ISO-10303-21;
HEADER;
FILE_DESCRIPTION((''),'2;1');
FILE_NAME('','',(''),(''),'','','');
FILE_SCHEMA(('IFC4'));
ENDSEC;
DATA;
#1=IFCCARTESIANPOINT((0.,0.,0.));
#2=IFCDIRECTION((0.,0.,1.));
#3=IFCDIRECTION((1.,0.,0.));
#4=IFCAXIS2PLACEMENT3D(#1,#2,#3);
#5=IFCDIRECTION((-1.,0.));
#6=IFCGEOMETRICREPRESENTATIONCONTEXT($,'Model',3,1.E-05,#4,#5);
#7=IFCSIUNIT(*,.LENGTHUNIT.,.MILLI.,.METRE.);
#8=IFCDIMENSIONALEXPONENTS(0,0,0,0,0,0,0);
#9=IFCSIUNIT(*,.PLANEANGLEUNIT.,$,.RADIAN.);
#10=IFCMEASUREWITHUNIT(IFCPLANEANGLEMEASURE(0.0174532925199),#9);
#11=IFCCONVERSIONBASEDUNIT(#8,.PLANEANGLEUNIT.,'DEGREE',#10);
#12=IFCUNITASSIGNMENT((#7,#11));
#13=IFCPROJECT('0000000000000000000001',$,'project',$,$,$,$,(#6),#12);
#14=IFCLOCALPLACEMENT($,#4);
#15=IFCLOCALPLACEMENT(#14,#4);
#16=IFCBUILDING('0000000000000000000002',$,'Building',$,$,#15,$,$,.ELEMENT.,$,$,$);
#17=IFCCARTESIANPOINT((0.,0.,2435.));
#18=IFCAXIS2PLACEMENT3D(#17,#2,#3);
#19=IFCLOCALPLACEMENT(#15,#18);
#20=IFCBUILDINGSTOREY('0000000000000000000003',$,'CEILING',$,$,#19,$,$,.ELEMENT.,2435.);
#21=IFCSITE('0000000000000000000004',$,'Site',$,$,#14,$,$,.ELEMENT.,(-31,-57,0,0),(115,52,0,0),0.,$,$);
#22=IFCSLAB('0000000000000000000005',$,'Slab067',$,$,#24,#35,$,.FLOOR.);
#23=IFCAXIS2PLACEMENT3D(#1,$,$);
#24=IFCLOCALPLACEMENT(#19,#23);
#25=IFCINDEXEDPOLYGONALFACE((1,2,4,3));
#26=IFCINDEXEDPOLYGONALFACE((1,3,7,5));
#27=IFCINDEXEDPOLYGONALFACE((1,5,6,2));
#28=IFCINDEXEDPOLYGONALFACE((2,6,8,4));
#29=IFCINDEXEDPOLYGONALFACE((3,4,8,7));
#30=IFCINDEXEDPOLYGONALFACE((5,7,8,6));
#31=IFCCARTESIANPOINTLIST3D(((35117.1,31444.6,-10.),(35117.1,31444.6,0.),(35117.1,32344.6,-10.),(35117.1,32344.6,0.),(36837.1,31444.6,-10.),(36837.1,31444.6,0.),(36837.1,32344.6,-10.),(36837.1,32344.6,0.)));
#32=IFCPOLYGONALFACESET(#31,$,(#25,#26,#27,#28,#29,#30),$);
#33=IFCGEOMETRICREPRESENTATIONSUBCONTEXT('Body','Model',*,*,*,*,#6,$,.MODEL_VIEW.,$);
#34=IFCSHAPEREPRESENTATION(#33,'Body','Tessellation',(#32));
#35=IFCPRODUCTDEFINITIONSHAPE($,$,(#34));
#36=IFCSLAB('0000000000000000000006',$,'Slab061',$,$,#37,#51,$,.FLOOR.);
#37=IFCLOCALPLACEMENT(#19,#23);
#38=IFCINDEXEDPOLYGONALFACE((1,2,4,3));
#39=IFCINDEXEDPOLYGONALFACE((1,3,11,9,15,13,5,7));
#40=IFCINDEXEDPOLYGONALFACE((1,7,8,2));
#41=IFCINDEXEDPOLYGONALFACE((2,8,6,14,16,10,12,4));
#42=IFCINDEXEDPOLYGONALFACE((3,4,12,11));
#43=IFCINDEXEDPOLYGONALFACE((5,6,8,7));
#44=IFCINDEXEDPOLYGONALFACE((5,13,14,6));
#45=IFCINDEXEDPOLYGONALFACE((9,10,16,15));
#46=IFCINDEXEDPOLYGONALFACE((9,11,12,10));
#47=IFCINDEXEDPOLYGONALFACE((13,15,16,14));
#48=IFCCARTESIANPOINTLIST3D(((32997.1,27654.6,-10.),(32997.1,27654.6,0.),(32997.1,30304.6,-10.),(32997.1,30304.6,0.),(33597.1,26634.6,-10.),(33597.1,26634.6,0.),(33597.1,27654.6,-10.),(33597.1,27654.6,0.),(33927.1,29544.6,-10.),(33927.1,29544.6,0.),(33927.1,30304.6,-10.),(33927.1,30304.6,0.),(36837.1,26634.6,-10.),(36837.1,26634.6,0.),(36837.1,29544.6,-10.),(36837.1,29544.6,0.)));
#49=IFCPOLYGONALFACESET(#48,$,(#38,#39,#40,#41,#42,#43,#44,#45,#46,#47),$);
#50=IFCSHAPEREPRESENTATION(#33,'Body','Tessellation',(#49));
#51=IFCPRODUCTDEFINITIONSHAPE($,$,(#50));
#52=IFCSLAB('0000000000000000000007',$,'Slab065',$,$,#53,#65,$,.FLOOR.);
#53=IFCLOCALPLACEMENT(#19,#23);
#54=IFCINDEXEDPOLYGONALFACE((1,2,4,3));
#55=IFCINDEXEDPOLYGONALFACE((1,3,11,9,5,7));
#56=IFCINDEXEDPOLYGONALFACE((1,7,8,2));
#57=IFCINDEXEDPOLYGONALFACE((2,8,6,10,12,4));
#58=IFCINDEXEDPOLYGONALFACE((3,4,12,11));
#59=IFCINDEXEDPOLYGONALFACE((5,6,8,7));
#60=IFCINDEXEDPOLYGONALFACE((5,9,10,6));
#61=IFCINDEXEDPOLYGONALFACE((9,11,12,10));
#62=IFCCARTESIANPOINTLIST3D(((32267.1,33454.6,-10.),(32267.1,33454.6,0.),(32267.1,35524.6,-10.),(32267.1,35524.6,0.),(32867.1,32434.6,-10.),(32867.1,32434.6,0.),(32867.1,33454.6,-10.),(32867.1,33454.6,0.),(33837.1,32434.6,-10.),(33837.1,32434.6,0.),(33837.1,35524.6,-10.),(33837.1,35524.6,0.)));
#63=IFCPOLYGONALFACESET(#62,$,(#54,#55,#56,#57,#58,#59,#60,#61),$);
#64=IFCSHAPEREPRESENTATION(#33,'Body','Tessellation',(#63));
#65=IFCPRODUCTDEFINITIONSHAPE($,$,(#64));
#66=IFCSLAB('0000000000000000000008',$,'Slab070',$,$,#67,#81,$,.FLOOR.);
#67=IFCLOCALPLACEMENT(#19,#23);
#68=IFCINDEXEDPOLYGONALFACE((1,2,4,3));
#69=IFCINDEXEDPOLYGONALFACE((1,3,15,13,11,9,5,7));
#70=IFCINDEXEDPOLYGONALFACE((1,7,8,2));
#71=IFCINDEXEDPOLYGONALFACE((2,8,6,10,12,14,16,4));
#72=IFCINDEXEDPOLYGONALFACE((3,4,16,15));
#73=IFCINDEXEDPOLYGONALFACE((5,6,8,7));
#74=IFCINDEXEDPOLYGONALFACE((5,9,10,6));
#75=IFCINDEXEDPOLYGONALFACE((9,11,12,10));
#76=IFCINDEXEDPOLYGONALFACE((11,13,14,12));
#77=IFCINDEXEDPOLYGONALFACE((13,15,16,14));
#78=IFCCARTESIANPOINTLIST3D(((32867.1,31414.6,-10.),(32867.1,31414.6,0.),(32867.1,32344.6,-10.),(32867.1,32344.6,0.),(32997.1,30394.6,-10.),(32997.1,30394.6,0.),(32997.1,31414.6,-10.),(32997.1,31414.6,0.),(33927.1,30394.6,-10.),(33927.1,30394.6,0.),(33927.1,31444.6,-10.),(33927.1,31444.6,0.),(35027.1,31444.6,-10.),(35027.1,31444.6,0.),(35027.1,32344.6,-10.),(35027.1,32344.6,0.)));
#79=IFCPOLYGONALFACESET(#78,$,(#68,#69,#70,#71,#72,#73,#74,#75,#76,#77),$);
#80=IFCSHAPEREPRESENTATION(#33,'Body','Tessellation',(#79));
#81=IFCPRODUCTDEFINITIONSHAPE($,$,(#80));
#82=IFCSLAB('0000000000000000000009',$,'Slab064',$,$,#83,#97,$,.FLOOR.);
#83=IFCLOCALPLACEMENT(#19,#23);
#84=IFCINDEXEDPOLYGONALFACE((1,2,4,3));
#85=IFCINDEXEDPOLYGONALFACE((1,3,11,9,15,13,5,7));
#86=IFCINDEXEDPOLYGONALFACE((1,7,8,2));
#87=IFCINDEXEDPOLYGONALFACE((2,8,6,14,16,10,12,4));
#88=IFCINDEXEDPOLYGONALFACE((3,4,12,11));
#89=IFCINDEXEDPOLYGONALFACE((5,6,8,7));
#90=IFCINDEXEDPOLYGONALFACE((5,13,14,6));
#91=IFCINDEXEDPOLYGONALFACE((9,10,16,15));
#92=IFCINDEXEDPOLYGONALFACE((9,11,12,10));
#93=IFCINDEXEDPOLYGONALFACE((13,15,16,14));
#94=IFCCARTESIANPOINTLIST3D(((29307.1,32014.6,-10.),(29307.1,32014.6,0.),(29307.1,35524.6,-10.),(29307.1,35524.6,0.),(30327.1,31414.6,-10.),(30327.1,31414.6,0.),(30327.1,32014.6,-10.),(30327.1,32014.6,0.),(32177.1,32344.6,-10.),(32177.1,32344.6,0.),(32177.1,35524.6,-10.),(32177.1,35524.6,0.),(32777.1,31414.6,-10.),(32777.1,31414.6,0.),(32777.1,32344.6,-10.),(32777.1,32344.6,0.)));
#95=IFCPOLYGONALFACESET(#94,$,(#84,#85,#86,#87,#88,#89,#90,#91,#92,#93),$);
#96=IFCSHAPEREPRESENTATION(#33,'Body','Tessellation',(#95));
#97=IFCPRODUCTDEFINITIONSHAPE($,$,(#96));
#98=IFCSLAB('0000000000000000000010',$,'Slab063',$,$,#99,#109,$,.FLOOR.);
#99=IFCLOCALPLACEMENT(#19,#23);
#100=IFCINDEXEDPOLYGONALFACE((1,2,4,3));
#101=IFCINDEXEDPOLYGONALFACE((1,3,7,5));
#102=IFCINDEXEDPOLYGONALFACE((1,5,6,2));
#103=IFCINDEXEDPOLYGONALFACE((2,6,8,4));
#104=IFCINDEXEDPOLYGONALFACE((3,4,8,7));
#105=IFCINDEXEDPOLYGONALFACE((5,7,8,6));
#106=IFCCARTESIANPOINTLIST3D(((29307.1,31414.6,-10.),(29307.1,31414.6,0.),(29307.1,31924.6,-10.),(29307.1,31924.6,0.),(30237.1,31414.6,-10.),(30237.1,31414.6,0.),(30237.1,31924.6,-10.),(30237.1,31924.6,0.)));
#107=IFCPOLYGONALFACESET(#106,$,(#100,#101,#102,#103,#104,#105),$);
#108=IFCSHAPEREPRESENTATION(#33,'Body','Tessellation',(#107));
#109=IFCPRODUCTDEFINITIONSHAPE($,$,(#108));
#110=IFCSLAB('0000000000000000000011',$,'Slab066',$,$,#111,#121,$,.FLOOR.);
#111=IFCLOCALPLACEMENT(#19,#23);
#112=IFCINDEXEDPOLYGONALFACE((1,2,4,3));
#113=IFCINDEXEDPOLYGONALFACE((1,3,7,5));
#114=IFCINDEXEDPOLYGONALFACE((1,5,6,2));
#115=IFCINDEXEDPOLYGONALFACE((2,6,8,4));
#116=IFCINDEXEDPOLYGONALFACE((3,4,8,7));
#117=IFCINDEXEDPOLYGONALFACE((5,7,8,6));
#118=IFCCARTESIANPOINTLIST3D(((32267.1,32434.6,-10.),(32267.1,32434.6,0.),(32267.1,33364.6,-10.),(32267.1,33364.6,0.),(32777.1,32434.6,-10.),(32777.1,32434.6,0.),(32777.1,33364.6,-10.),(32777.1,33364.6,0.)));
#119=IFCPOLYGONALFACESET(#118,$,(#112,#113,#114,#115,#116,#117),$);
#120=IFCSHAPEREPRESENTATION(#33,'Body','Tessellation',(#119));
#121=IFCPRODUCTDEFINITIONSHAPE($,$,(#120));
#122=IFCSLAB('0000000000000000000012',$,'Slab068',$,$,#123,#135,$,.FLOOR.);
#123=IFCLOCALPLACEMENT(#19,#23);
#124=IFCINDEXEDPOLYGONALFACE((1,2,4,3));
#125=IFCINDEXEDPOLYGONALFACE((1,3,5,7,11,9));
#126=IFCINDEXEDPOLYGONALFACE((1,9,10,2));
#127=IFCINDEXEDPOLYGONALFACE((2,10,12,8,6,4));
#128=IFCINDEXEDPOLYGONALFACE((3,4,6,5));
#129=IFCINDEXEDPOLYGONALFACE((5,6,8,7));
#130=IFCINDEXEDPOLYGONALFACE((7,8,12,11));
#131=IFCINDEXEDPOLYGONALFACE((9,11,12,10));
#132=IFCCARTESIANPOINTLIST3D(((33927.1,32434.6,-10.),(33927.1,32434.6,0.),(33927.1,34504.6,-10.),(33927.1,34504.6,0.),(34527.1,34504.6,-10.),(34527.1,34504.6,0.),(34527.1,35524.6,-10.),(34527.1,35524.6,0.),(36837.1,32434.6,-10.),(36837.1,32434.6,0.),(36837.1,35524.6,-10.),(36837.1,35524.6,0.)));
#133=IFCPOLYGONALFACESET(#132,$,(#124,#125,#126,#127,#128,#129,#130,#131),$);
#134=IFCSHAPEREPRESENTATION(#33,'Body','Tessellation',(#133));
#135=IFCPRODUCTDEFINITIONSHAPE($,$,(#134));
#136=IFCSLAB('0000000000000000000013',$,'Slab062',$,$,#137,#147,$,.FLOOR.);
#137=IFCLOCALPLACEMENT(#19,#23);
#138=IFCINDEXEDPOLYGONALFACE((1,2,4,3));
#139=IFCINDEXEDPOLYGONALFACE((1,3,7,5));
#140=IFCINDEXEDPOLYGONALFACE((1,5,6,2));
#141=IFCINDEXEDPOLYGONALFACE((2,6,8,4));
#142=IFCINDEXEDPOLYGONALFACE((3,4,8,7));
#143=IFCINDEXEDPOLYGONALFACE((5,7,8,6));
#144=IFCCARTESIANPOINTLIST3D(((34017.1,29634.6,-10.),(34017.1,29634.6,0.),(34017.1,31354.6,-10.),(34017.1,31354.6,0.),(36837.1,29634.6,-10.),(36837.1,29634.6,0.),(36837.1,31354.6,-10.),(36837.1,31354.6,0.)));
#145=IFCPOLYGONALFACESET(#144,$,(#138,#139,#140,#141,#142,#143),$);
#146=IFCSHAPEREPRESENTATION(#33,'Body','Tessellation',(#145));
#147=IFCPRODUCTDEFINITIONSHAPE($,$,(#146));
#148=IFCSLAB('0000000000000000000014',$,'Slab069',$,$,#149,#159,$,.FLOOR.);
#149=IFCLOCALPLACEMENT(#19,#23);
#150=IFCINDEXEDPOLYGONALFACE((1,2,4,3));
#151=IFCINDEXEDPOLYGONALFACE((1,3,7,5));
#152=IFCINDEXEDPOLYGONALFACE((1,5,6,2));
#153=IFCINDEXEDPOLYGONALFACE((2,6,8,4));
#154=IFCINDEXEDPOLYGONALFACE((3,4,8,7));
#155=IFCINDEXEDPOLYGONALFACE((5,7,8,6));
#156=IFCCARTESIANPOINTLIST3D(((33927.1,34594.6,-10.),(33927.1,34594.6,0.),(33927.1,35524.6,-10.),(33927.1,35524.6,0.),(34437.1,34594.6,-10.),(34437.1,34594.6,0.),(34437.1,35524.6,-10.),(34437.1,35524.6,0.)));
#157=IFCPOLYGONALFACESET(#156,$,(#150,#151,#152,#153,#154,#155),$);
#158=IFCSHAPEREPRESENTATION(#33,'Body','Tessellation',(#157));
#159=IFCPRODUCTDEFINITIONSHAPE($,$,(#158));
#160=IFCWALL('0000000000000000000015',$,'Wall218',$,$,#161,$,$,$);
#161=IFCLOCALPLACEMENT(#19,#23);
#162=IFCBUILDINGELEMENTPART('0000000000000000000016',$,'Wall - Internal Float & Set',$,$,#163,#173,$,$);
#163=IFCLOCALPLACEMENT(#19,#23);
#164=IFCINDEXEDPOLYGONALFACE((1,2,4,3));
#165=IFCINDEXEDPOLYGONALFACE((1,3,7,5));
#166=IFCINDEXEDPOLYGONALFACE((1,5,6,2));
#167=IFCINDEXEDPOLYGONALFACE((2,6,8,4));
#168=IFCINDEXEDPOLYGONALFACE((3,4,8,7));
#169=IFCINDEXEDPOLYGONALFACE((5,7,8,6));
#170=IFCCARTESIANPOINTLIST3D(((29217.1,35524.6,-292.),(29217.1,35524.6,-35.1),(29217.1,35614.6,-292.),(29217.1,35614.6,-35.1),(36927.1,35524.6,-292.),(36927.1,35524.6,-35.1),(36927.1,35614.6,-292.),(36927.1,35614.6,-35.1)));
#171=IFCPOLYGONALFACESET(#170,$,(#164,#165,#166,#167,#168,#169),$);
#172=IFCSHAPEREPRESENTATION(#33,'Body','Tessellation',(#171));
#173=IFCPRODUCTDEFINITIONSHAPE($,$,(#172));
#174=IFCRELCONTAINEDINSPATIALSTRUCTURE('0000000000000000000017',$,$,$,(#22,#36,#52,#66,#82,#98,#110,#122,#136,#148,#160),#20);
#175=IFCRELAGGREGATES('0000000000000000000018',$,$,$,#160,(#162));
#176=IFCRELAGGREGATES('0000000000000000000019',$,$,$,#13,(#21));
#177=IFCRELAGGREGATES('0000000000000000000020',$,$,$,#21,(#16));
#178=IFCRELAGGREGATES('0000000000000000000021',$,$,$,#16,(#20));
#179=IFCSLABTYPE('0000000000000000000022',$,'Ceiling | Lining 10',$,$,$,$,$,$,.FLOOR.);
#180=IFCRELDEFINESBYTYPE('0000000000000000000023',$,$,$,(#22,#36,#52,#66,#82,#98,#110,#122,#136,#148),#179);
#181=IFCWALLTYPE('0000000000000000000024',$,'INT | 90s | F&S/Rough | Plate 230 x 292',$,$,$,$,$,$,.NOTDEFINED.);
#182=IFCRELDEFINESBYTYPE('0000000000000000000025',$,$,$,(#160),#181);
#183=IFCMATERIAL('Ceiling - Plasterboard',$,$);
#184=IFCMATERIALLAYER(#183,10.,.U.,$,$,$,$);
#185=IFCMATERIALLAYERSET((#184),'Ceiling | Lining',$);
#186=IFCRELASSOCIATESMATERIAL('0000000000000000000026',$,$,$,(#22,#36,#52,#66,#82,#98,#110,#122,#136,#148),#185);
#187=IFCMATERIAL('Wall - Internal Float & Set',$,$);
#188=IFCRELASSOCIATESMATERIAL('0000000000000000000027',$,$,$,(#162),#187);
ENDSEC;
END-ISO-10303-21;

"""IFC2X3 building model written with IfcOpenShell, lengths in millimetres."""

from ifc_helpers import new_model, entity, si_unit, converted_unit, direction, frame, origin_with_axes, place, context, subcontext, project, spatial, polyline, outline, extrude, material, layer, layer_set, layer_usage, type_object, element, aggregate, save


model = new_model("IFC2X3")

# Units and contexts
model_context = context("Model", 3, precision=1e-05, world=origin_with_axes(), true_north=direction((-1.0, 0.0)))
body_context = subcontext(model_context, "Body", "Model", "MODEL_VIEW")
ifc_project = project(units=[si_unit("LENGTHUNIT", "METRE", prefix="MILLI"), converted_unit("PLANEANGLEUNIT", "DEGREE", entity("IfcPlaneAngleMeasure", 0.0174532925199), si_unit("PLANEANGLEUNIT", "RADIAN"), dimensions=[0, 0, 0, 0, 0, 0, 0])], contexts=[model_context])

# Site, building, storey
site_placement = place(None, origin_with_axes())
site = spatial("IfcSite", under=ifc_project, at=site_placement, Name="Site", CompositionType="ELEMENT", RefLatitude=(-31, -57, 0, 0), RefLongitude=(115, 52, 0, 0), RefElevation=0.0)
building_placement = place(site_placement, origin_with_axes())
building = spatial("IfcBuilding", under=site, at=building_placement, Name="Building", CompositionType="ELEMENT")
storey_placement = place(building_placement, frame((0.0, 0.0, 2435.0), z_axis=(0.0, 0.0, 1.0), x_axis=(1.0, 0.0, 0.0)))
storey = spatial("IfcBuildingStorey", under=building, at=storey_placement, Name="CEILING", CompositionType="ELEMENT", Elevation=2435.0)

# Slabs
ifc_material_1 = material(Name="Ceiling - Plasterboard")
ifc_layer_1 = layer(ifc_material_1, 10.0, ventilated="UNKNOWN")
ifc_layer_set_1 = layer_set([ifc_layer_1], Name="Ceiling | Lining")
ifc_layer_usage_1 = layer_usage(ifc_layer_set_1, "AXIS3", "NEGATIVE", 10.0)
slab_type_1 = type_object("IfcSlabType", Name="Ceiling | Lining 10", PredefinedType="FLOOR")
slab_1_placement = place(storey_placement, frame((35117.1, 31444.6, 0.0), z_axis=(0.0, 0.0, 1.0), x_axis=(1.0, 0.0, 0.0)))
element("IfcSlab", 1, at=slab_1_placement, inside=storey, type_object=slab_type_1, material=ifc_layer_usage_1, Name="Slab067", PredefinedType="FLOOR", context=body_context, shape_type="SweptSolid", body=[
    extrude(outline(polyline([(0.0, 0.0), (1720.0, 0.0), (1720.0, 900.0), (0.0, 900.0), (0.0, 0.0)])), frame((0.0, 0.0, -10.0), z_axis=(0.0, 0.0, 1.0), x_axis=(1.0, 0.0, 0.0)), (0.0, 0.0, 1.0), 10.0),
])
ifc_layer_usage_2 = layer_usage(ifc_layer_set_1, "AXIS3", "NEGATIVE", 10.0)
slab_2_placement = place(storey_placement, frame((32997.1, 30304.6, 0.0), z_axis=(0.0, 0.0, 1.0), x_axis=(1.0, 0.0, 0.0)))
element("IfcSlab", 2, at=slab_2_placement, inside=storey, type_object=slab_type_1, material=ifc_layer_usage_2, Name="Slab061", PredefinedType="FLOOR", context=body_context, shape_type="SweptSolid", body=[
    extrude(outline(polyline([(0.0, 0.0), (0.0, -2650.0), (600.0, -2650.0), (600.0, -3670.0), (3840.0, -3670.0), (3840.0, -760.0), (930.0, -760.0), (930.0, 0.0), (0.0, 0.0)])), frame((0.0, 0.0, -10.0), z_axis=(0.0, 0.0, 1.0), x_axis=(1.0, 0.0, 0.0)), (0.0, 0.0, 1.0), 10.0),
])
ifc_layer_usage_3 = layer_usage(ifc_layer_set_1, "AXIS3", "NEGATIVE", 10.0)
slab_3_placement = place(storey_placement, frame((32267.1, 35524.6, 0.0), z_axis=(0.0, 0.0, 1.0), x_axis=(1.0, 0.0, 0.0)))
element("IfcSlab", 3, at=slab_3_placement, inside=storey, type_object=slab_type_1, material=ifc_layer_usage_3, Name="Slab065", PredefinedType="FLOOR", context=body_context, shape_type="SweptSolid", body=[
    extrude(outline(polyline([(0.0, 0.0), (0.0, -2070.0), (600.0, -2070.0), (600.0, -3090.0), (1570.0, -3090.0), (1570.0, 0.0), (0.0, 0.0)])), frame((0.0, 0.0, -10.0), z_axis=(0.0, 0.0, 1.0), x_axis=(1.0, 0.0, 0.0)), (0.0, 0.0, 1.0), 10.0),
])
ifc_layer_usage_4 = layer_usage(ifc_layer_set_1, "AXIS3", "NEGATIVE", 10.0)
slab_4_placement = place(storey_placement, frame((32867.1, 31414.6, 0.0), z_axis=(0.0, 0.0, 1.0), x_axis=(1.0, 0.0, 0.0)))
element("IfcSlab", 4, at=slab_4_placement, inside=storey, type_object=slab_type_1, material=ifc_layer_usage_4, Name="Slab070", PredefinedType="FLOOR", context=body_context, shape_type="SweptSolid", body=[
    extrude(outline(polyline([(0.0, 0.0), (130.0, 0.0), (130.0, -1020.0), (1060.0, -1020.0), (1060.0, 30.0), (2160.0, 30.0), (2160.0, 930.0), (0.0, 930.0), (0.0, 0.0)])), frame((0.0, 0.0, -10.0), z_axis=(0.0, 0.0, 1.0), x_axis=(1.0, 0.0, 0.0)), (0.0, 0.0, 1.0), 10.0),
])
ifc_layer_usage_5 = layer_usage(ifc_layer_set_1, "AXIS3", "NEGATIVE", 10.0)
slab_5_placement = place(storey_placement, frame((32177.1, 35524.6, 0.0), z_axis=(0.0, 0.0, 1.0), x_axis=(1.0, 0.0, 0.0)))
element("IfcSlab", 5, at=slab_5_placement, inside=storey, type_object=slab_type_1, material=ifc_layer_usage_5, Name="Slab064", PredefinedType="FLOOR", context=body_context, shape_type="SweptSolid", body=[
    extrude(outline(polyline([(0.0, 0.0), (-2870.0, 0.0), (-2870.0, -3510.0), (-1850.0, -3510.0), (-1850.0, -4110.0), (600.0, -4110.0), (600.0, -3180.0), (0.0, -3180.0), (0.0, 0.0)])), frame((0.0, 0.0, -10.0), z_axis=(0.0, 0.0, 1.0), x_axis=(1.0, 0.0, 0.0)), (0.0, 0.0, 1.0), 10.0),
])
ifc_layer_usage_6 = layer_usage(ifc_layer_set_1, "AXIS3", "NEGATIVE", 10.0)
slab_6_placement = place(storey_placement, frame((30237.1, 31924.6, 0.0), z_axis=(0.0, 0.0, 1.0), x_axis=(1.0, 0.0, 0.0)))
element("IfcSlab", 6, at=slab_6_placement, inside=storey, type_object=slab_type_1, material=ifc_layer_usage_6, Name="Slab063", PredefinedType="FLOOR", context=body_context, shape_type="SweptSolid", body=[
    extrude(outline(polyline([(0.0, 0.0), (-930.0, 0.0), (-930.0, -510.0), (0.0, -510.0), (0.0, 0.0)])), frame((0.0, 0.0, -10.0), z_axis=(0.0, 0.0, 1.0), x_axis=(1.0, 0.0, 0.0)), (0.0, 0.0, 1.0), 10.0),
])
ifc_layer_usage_7 = layer_usage(ifc_layer_set_1, "AXIS3", "NEGATIVE", 10.0)
slab_7_placement = place(storey_placement, frame((32267.1, 33364.6, 0.0), z_axis=(0.0, 0.0, 1.0), x_axis=(1.0, 0.0, 0.0)))
element("IfcSlab", 7, at=slab_7_placement, inside=storey, type_object=slab_type_1, material=ifc_layer_usage_7, Name="Slab066", PredefinedType="FLOOR", context=body_context, shape_type="SweptSolid", body=[
    extrude(outline(polyline([(0.0, 0.0), (0.0, -930.0), (510.0, -930.0), (510.0, 0.0), (0.0, 0.0)])), frame((0.0, 0.0, -10.0), z_axis=(0.0, 0.0, 1.0), x_axis=(1.0, 0.0, 0.0)), (0.0, 0.0, 1.0), 10.0),
])
ifc_layer_usage_8 = layer_usage(ifc_layer_set_1, "AXIS3", "NEGATIVE", 10.0)
slab_8_placement = place(storey_placement, frame((33927.1, 34504.6, 0.0), z_axis=(0.0, 0.0, 1.0), x_axis=(1.0, 0.0, 0.0)))
element("IfcSlab", 8, at=slab_8_placement, inside=storey, type_object=slab_type_1, material=ifc_layer_usage_8, Name="Slab068", PredefinedType="FLOOR", context=body_context, shape_type="SweptSolid", body=[
    extrude(outline(polyline([(0.0, 0.0), (0.0, -2070.0), (2910.0, -2070.0), (2910.0, 1020.0), (600.0, 1020.0), (600.0, 0.0), (0.0, 0.0)])), frame((0.0, 0.0, -10.0), z_axis=(0.0, 0.0, 1.0), x_axis=(1.0, 0.0, 0.0)), (0.0, 0.0, 1.0), 10.0),
])
ifc_layer_usage_9 = layer_usage(ifc_layer_set_1, "AXIS3", "NEGATIVE", 10.0)
slab_9_placement = place(storey_placement, frame((36837.1, 31354.6, 0.0), z_axis=(0.0, 0.0, 1.0), x_axis=(1.0, 0.0, 0.0)))
element("IfcSlab", 9, at=slab_9_placement, inside=storey, type_object=slab_type_1, material=ifc_layer_usage_9, Name="Slab062", PredefinedType="FLOOR", context=body_context, shape_type="SweptSolid", body=[
    extrude(outline(polyline([(0.0, 0.0), (-2820.0, 0.0), (-2820.0, -1720.0), (0.0, -1720.0), (0.0, 0.0)])), frame((0.0, 0.0, -10.0), z_axis=(0.0, 0.0, 1.0), x_axis=(1.0, 0.0, 0.0)), (0.0, 0.0, 1.0), 10.0),
])
ifc_layer_usage_10 = layer_usage(ifc_layer_set_1, "AXIS3", "NEGATIVE", 10.0)
slab_10_placement = place(storey_placement, frame((33927.1, 35524.6, 0.0), z_axis=(0.0, 0.0, 1.0), x_axis=(1.0, 0.0, 0.0)))
element("IfcSlab", 10, at=slab_10_placement, inside=storey, type_object=slab_type_1, material=ifc_layer_usage_10, Name="Slab069", PredefinedType="FLOOR", context=body_context, shape_type="SweptSolid", body=[
    extrude(outline(polyline([(0.0, 0.0), (0.0, -930.0), (510.0, -930.0), (510.0, 0.0), (0.0, 0.0)])), frame((0.0, 0.0, -10.0), z_axis=(0.0, 0.0, 1.0), x_axis=(1.0, 0.0, 0.0)), (0.0, 0.0, 1.0), 10.0),
])

# Wall, building element part
wall_type = type_object("IfcWallType", Name="INT | 90s | F&S/Rough | Plate 230 x 292", PredefinedType="NOTDEFINED")
wall_1_placement = place(storey_placement, frame((29217.1, 35614.6, -292.0), z_axis=(0.0, 0.0, 1.0), x_axis=(1.0, 0.0, 0.0)))
wall_1 = element("IfcWall", 11, at=wall_1_placement, inside=storey, type_object=wall_type, Name="Wall218")
ifc_material_2 = material(Name="Wall - Internal Float & Set")
building_element_part_1_placement = place(wall_1_placement, origin_with_axes())
building_element_part_1 = element("IfcBuildingElementPart", 12, at=building_element_part_1_placement, material=ifc_material_2, Name="Wall - Internal Float & Set", context=body_context, shape_type="SweptSolid", body=[
    extrude(outline(polyline([(-90.0, 256.9), (-90.0, 0.0), (0.0, 0.0), (0.0, 256.9), (-90.0, 256.9)])), frame((0.0, 0.0, 0.0), z_axis=(1.0, 0.0, 0.0), x_axis=(0.0, 1.0, 0.0)), (0.0, 0.0, 1.0), 7710.0),
])
aggregate(wall_1, [building_element_part_1])

save(model, "model.ifc")
